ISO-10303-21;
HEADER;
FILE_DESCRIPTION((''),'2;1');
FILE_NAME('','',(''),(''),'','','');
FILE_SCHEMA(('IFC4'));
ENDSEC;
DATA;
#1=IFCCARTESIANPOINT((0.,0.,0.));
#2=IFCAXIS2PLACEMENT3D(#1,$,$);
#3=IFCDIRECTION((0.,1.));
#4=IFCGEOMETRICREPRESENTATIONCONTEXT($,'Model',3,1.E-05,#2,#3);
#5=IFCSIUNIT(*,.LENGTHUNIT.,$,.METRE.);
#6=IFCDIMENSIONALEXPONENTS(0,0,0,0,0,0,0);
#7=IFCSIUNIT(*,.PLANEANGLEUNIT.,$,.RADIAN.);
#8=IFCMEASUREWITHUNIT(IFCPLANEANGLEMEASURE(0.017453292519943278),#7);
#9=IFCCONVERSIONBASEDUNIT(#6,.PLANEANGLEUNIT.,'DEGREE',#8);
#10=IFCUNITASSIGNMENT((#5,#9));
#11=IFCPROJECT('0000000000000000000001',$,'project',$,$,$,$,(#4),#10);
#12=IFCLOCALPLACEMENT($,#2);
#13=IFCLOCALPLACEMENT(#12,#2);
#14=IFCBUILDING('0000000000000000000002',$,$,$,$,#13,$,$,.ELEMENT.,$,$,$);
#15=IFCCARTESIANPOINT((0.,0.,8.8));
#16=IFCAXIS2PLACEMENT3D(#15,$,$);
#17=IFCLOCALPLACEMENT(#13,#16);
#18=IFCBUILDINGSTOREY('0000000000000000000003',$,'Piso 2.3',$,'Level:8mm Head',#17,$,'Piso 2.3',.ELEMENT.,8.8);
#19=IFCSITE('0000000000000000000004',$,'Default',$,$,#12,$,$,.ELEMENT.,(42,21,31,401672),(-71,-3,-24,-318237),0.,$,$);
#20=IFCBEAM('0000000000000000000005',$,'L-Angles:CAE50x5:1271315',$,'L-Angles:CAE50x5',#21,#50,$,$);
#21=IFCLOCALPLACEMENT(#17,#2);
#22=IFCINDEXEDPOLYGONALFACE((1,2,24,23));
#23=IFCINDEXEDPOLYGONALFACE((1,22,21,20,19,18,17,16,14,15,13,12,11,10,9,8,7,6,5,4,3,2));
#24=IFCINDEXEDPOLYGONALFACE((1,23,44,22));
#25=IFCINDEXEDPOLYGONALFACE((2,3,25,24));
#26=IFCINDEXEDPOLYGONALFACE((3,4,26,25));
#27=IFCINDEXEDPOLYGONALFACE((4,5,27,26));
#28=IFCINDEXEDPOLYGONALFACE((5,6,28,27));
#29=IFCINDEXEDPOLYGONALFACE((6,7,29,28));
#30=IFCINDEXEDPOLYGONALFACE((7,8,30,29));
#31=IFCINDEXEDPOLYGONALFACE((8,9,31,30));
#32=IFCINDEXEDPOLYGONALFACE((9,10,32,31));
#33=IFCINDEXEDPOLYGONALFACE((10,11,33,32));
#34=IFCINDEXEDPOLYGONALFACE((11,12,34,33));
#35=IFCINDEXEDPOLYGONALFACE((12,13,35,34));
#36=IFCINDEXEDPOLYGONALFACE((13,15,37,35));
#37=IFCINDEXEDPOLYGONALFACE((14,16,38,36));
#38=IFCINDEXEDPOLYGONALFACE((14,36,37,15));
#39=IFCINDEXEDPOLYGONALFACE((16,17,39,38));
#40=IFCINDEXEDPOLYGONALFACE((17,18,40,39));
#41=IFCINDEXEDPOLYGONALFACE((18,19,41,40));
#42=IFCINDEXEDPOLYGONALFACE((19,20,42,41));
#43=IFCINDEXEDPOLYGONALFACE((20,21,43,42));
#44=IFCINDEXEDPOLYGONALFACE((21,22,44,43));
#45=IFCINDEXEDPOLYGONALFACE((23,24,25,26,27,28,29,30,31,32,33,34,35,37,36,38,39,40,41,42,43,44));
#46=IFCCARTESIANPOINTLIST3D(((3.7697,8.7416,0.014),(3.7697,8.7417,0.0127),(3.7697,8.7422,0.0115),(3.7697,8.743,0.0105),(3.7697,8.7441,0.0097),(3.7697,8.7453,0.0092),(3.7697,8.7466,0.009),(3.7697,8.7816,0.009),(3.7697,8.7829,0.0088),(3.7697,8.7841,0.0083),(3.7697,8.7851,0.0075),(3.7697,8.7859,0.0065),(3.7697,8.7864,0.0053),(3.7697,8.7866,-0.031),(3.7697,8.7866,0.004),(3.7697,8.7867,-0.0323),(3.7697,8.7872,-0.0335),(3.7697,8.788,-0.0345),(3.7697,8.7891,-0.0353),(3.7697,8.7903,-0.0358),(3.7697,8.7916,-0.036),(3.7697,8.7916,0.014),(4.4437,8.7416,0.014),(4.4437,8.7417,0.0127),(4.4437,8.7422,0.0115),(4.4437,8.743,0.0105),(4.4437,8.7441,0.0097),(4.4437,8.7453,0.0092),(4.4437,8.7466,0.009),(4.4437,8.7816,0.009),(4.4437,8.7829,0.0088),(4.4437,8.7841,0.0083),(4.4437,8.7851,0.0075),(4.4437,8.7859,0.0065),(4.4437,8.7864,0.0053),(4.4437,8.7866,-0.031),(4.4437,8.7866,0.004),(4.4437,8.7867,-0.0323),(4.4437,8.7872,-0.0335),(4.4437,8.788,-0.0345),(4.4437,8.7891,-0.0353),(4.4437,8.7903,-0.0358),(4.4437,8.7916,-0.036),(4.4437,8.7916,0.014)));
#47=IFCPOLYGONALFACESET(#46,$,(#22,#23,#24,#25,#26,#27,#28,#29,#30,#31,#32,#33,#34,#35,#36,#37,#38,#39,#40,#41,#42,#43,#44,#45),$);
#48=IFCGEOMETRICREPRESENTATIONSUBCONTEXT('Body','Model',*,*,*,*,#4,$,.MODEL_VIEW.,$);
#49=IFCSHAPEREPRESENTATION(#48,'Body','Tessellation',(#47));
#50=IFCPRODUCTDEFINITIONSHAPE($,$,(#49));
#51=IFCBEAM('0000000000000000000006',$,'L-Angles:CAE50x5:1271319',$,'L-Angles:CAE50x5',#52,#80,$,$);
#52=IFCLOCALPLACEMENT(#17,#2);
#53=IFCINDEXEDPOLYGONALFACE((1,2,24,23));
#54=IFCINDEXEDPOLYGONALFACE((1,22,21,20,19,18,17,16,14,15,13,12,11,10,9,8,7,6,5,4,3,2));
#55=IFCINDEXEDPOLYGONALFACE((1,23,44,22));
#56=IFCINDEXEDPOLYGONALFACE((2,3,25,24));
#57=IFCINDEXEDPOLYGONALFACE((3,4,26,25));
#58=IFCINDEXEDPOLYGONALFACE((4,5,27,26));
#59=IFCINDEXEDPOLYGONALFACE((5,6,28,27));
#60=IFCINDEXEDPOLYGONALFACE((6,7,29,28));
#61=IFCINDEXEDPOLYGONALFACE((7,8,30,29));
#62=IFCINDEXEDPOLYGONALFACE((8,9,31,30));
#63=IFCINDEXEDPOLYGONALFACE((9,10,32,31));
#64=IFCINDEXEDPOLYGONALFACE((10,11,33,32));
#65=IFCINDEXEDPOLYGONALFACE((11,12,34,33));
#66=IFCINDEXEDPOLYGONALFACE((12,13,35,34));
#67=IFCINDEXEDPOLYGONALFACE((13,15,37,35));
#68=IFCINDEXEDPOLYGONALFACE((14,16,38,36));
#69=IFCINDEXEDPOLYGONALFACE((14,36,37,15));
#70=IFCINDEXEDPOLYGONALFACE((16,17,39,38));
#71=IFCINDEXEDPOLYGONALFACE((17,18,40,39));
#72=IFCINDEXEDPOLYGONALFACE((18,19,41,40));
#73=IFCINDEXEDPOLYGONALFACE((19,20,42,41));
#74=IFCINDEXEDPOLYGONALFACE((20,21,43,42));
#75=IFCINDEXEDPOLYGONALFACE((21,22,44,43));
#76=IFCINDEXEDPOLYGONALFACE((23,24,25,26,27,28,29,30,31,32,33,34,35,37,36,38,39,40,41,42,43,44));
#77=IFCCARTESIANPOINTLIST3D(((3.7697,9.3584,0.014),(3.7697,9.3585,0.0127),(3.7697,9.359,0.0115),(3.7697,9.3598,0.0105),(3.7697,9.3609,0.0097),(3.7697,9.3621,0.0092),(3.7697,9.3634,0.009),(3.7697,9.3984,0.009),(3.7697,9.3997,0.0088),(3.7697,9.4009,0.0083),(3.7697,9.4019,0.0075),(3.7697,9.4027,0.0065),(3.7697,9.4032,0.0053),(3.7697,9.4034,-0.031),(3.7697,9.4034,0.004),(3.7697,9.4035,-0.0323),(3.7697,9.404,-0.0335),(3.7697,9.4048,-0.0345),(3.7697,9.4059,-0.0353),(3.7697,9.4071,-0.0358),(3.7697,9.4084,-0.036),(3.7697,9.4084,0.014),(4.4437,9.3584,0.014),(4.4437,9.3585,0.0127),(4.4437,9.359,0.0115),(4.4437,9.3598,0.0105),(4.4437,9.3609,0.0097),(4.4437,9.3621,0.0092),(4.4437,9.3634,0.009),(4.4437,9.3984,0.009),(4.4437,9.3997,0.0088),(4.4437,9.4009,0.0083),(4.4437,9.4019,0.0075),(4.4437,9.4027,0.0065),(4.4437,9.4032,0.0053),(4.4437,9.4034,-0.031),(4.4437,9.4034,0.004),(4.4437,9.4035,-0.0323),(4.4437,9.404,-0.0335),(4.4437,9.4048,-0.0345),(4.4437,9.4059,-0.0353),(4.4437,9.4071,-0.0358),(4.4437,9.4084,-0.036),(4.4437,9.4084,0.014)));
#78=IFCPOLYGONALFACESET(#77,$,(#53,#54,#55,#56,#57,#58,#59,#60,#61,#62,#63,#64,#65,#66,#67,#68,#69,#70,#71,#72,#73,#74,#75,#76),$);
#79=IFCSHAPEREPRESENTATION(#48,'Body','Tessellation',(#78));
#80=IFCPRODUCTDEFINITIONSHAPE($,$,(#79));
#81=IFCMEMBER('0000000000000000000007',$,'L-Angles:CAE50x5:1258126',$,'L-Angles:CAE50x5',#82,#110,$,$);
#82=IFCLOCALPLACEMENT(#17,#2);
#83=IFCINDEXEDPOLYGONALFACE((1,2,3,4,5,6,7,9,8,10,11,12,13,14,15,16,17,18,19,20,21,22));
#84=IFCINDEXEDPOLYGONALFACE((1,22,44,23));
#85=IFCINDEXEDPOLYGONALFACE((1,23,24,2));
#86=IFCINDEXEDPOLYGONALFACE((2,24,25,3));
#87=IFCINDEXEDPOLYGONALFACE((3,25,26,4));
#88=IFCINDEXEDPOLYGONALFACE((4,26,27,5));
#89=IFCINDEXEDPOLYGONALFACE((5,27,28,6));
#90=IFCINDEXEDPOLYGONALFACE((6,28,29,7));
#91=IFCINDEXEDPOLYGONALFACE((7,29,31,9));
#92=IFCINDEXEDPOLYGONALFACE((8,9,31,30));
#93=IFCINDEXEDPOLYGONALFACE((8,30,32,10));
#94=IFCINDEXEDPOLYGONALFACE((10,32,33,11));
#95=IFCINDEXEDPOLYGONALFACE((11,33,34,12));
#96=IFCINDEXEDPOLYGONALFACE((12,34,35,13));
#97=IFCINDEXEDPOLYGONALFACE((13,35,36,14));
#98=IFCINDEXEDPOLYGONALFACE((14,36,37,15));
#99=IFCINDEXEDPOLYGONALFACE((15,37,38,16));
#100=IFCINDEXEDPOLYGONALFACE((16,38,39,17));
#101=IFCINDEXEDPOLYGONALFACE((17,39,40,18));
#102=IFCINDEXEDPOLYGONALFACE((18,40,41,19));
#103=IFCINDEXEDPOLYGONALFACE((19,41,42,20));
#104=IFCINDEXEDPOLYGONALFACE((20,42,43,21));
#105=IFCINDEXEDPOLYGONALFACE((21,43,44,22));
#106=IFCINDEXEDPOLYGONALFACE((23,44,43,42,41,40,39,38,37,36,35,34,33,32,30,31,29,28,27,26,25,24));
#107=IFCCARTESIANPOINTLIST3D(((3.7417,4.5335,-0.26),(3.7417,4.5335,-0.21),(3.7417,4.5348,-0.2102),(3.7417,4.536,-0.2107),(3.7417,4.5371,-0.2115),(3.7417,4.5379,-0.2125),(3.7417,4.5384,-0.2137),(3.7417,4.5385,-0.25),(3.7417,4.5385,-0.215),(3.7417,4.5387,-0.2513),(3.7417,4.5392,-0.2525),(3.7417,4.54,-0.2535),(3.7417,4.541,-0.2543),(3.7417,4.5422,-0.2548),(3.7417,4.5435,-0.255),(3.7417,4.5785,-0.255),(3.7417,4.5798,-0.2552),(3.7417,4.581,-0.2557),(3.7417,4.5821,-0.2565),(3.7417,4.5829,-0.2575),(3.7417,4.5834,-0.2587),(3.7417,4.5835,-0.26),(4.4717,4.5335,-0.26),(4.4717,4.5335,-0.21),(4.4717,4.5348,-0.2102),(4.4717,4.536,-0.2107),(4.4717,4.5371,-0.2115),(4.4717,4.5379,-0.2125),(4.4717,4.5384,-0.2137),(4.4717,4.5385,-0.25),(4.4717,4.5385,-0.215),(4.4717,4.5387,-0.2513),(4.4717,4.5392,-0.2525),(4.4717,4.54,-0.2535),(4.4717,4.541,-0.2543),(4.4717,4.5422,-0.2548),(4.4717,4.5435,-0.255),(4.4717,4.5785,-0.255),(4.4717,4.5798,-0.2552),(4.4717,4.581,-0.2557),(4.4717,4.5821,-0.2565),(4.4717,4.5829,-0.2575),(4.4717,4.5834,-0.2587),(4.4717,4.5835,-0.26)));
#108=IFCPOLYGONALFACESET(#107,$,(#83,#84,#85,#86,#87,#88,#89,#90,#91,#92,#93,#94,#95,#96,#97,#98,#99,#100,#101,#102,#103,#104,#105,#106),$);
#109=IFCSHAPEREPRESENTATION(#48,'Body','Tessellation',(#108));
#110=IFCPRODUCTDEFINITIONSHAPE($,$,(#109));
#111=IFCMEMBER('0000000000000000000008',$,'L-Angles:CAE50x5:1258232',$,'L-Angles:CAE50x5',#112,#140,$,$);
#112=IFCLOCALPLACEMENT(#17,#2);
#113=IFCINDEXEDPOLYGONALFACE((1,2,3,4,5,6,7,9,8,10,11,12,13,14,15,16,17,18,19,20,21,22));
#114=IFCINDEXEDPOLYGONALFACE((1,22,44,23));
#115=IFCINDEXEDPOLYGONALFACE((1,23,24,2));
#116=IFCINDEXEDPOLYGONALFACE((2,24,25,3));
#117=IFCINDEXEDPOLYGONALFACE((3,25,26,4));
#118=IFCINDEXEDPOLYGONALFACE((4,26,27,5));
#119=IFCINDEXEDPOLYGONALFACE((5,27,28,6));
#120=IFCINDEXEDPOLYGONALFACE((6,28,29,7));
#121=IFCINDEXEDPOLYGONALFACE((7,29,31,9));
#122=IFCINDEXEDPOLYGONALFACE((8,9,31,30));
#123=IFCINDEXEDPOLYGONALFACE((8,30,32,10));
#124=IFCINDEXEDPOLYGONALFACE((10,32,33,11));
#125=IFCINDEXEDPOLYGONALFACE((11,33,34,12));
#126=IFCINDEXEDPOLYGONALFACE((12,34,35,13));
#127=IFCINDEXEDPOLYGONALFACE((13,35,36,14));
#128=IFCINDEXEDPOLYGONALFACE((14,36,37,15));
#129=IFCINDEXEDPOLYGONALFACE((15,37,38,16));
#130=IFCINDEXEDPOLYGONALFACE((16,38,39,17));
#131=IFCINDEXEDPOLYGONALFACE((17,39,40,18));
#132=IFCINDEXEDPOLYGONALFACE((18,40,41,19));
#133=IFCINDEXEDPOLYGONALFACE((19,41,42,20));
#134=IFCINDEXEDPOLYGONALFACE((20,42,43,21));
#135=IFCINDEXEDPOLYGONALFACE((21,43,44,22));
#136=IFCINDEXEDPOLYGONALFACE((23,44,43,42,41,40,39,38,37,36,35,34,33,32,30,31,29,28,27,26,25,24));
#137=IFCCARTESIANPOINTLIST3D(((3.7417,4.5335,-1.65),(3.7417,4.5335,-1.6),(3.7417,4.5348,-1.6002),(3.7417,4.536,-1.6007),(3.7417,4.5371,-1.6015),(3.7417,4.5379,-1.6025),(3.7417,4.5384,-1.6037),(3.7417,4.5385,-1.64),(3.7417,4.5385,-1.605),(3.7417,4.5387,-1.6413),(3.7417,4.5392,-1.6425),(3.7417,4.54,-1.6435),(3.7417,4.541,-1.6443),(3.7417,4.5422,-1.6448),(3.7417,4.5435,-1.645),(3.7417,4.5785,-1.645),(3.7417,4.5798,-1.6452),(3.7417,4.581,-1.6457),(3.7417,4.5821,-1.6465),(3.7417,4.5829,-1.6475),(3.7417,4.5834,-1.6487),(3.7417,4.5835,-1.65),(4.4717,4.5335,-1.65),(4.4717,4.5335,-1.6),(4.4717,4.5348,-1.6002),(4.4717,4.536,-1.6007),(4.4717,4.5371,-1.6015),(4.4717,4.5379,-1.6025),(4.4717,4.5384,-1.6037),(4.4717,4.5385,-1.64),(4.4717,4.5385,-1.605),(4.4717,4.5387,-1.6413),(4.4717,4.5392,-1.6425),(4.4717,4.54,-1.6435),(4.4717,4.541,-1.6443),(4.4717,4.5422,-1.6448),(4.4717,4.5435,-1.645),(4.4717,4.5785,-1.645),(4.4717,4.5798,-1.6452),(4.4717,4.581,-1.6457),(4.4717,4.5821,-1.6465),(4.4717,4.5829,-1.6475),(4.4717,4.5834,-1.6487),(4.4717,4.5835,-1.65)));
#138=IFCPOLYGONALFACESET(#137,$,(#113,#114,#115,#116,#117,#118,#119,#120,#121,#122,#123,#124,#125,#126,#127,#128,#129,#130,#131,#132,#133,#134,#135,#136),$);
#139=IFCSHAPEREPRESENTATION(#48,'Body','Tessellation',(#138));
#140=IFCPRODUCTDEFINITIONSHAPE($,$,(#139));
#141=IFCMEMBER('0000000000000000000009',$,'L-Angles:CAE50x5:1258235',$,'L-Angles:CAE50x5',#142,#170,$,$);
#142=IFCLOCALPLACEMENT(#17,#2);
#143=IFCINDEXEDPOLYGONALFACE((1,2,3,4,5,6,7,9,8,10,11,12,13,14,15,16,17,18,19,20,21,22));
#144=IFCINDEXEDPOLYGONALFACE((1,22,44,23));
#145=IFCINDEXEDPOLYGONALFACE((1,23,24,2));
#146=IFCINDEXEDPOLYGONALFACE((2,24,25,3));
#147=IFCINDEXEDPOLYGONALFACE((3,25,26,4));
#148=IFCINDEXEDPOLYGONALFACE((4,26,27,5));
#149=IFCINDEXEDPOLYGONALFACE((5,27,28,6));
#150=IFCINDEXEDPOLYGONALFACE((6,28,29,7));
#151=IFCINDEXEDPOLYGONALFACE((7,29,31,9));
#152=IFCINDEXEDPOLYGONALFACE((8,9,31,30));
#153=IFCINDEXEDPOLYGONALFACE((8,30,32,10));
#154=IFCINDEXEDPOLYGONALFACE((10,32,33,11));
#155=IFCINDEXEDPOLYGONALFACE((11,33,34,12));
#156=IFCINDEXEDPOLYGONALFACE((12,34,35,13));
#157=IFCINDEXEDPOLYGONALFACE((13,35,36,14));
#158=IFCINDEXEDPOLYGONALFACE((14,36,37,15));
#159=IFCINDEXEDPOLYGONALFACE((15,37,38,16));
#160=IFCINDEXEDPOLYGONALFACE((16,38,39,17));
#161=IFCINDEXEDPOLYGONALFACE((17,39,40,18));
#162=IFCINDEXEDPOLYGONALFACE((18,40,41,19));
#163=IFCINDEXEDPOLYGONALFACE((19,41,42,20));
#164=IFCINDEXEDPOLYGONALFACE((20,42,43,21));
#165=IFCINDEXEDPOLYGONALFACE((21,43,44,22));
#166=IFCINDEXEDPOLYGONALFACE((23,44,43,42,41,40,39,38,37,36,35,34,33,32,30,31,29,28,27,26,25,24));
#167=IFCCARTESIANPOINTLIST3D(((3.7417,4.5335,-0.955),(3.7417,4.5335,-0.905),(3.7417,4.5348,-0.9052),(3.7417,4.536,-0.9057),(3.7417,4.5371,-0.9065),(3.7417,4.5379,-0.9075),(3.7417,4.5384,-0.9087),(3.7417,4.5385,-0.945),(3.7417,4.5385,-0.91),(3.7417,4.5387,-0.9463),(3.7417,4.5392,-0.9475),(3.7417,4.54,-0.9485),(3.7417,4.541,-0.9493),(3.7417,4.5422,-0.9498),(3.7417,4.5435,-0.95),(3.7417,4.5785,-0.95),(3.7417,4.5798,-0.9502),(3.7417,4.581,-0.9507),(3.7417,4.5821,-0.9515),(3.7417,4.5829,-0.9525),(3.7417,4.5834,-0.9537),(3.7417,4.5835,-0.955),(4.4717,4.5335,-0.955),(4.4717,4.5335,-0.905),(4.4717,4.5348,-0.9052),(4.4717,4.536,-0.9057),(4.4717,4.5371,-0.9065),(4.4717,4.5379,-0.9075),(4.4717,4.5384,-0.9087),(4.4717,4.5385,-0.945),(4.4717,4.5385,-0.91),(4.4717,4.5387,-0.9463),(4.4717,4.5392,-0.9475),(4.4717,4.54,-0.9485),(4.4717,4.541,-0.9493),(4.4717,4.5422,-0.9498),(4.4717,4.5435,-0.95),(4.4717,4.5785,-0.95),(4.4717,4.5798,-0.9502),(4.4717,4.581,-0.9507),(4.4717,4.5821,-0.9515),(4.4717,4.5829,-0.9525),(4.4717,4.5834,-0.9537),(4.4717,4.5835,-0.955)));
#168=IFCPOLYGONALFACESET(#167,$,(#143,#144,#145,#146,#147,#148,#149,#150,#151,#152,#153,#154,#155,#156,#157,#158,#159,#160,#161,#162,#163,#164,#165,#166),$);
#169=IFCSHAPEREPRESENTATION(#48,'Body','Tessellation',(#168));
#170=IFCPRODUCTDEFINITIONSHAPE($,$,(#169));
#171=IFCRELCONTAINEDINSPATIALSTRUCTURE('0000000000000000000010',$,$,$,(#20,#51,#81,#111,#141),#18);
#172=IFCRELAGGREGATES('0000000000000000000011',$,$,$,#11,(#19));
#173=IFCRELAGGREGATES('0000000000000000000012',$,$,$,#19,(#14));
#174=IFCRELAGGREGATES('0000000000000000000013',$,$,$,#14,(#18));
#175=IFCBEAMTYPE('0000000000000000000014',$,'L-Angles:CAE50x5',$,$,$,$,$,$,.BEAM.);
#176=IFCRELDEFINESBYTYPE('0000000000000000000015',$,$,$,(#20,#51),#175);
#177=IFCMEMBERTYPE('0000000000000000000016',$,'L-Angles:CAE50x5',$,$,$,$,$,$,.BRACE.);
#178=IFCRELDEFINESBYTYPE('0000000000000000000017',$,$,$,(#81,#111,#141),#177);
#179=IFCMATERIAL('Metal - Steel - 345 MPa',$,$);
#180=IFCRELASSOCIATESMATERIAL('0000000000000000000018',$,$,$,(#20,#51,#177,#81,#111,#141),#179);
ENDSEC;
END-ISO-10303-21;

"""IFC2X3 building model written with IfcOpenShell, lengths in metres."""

from ifc_helpers import new_model, entity, si_unit, converted_unit, direction, frame, frame_2d, origin, place, context, subcontext, project, spatial, polyline, circle_curve, parameter, trimmed, segment, composite_curve, outline, extrude, source, transform, mapped, material, type_object, type_shapes, element, save


model = new_model("IFC2X3")

# Units and contexts
model_context = context("Model", 3, precision=1e-05, world=origin(), true_north=direction((0.0, 1.0)))
body_context = subcontext(model_context, "Body", "Model", "MODEL_VIEW")
ifc_project = project(units=[si_unit("LENGTHUNIT", "METRE"), converted_unit("PLANEANGLEUNIT", "DEGREE", entity("IfcPlaneAngleMeasure", 0.017453292519943278), si_unit("PLANEANGLEUNIT", "RADIAN"), dimensions=[0, 0, 0, 0, 0, 0, 0])], contexts=[model_context])

# Site, building, storey
site_placement = place(None, origin())
site = spatial("IfcSite", under=ifc_project, at=site_placement, Name="Default", CompositionType="ELEMENT", RefLatitude=(42, 21, 31, 401672), RefLongitude=(-71, -3, -24, -318237), RefElevation=0.0)
building_placement = place(site_placement, origin())
building = spatial("IfcBuilding", under=site, at=building_placement, CompositionType="ELEMENT")
storey_placement = place(building_placement, frame((0.0, 0.0, 8.8)))
storey = spatial("IfcBuildingStorey", under=building, at=storey_placement, Name="Piso 2.3", ObjectType="Level:8mm Head", LongName="Piso 2.3", CompositionType="ELEMENT", Elevation=8.8)

# Shared definitions
ifc_material = material(Name="Metal - Steel - 345 MPa")

# Beams
beam_type_1 = type_object("IfcBeamType", Name="L-Angles:CAE50x5", PredefinedType="BEAM")
beam_1_placement = place(storey_placement, frame((3.7067, 8.7776, 0.0)))
element("IfcBeam", 1, at=beam_1_placement, inside=storey, type_object=beam_type_1, material=ifc_material, Name="L-Angles:CAE50x5:1271315", ObjectType="L-Angles:CAE50x5", context=body_context, shape_type="SweptSolid", body=[
    extrude(outline(composite_curve([segment(polyline([(-0.0336, -0.0164), (0.0164, -0.0164)]), True, "CONTINUOUS"), segment(polyline([(0.0164, -0.0164), (0.0164, 0.0336)]), True, "CONTINUOUS"), segment(trimmed(circle_curve(frame_2d((0.0164, 0.0286), x_axis=(0.0, 1.0)), 0.005), [parameter(0.0)], [parameter(90.0)], True, "PARAMETER"), True, "CONTINUOUS"), segment(polyline([(0.0114, 0.0286), (0.0114, -0.0064)]), True, "CONTINUOUS"), segment(trimmed(circle_curve(frame_2d((0.0064, -0.0064), x_axis=(1.0, 0.0)), 0.005), [parameter(270.0)], [parameter(0.0)], True, "PARAMETER"), False, "CONTINUOUS"), segment(polyline([(0.0064, -0.0114), (-0.0286, -0.0114)]), True, "CONTINUOUS"), segment(trimmed(circle_curve(frame_2d((-0.0286, -0.0164), x_axis=(0.0, 1.0)), 0.005), [parameter(0.0)], [parameter(90.0)], True, "PARAMETER"), True, "CONTINUOUS")], self_intersect=False)), frame((0.063, -0.0024, -0.0024), z_axis=(1.0, 0.0, 0.0), x_axis=(0.0, 0.0, 1.0)), (0.0, 0.0, 1.0), 0.674),
])
beam_2_placement = place(storey_placement, frame((3.7067, 9.3944, 0.0)))
element("IfcBeam", 2, at=beam_2_placement, inside=storey, type_object=beam_type_1, material=ifc_material, Name="L-Angles:CAE50x5:1271319", ObjectType="L-Angles:CAE50x5", context=body_context, shape_type="SweptSolid", body=[
    extrude(outline(composite_curve([segment(polyline([(-0.0336, -0.0164), (0.0164, -0.0164)]), True, "CONTINUOUS"), segment(polyline([(0.0164, -0.0164), (0.0164, 0.0336)]), True, "CONTINUOUS"), segment(trimmed(circle_curve(frame_2d((0.0164, 0.0286), x_axis=(0.0, 1.0)), 0.005), [parameter(0.0)], [parameter(90.0)], True, "PARAMETER"), True, "CONTINUOUS"), segment(polyline([(0.0114, 0.0286), (0.0114, -0.0064)]), True, "CONTINUOUS"), segment(trimmed(circle_curve(frame_2d((0.0064, -0.0064), x_axis=(1.0, 0.0)), 0.005), [parameter(270.0)], [parameter(0.0)], True, "PARAMETER"), False, "CONTINUOUS"), segment(polyline([(0.0064, -0.0114), (-0.0286, -0.0114)]), True, "CONTINUOUS"), segment(trimmed(circle_curve(frame_2d((-0.0286, -0.0164), x_axis=(0.0, 1.0)), 0.005), [parameter(0.0)], [parameter(90.0)], True, "PARAMETER"), True, "CONTINUOUS")], self_intersect=False)), frame((0.063, -0.0024, -0.0024), z_axis=(1.0, 0.0, 0.0), x_axis=(0.0, 0.0, 1.0)), (0.0, 0.0, 1.0), 0.674),
])

# Members
member_type_1 = type_object("IfcMemberType", Name="L-Angles:CAE50x5", PredefinedType="BRACE", material=ifc_material)
shared_shape_1 = source(origin(), body_context, "Body", "SweptSolid", [
    extrude(outline(composite_curve([segment(polyline([(-0.0164, -0.0164), (0.0336, -0.0164)]), True, "CONTINUOUS"), segment(trimmed(circle_curve(frame_2d((0.0286, -0.0164), x_axis=(1.0, 0.0)), 0.005), [parameter(0.0)], [parameter(90.0)], True, "PARAMETER"), True, "CONTINUOUS"), segment(polyline([(0.0286, -0.0114), (-0.0064, -0.0114)]), True, "CONTINUOUS"), segment(trimmed(circle_curve(frame_2d((-0.0064, -0.0064), x_axis=(1.0, 0.0)), 0.005), [parameter(180.0)], [parameter(270.0)], True, "PARAMETER"), False, "CONTINUOUS"), segment(polyline([(-0.0114, -0.0064), (-0.0114, 0.0286)]), True, "CONTINUOUS"), segment(trimmed(circle_curve(frame_2d((-0.0164, 0.0286), x_axis=(1.0, 0.0)), 0.005), [parameter(0.0)], [parameter(90.0)], True, "PARAMETER"), True, "CONTINUOUS"), segment(polyline([(-0.0164, 0.0336), (-0.0164, -0.0164)]), True, "CONTINUOUS")], self_intersect=False)), frame((-0.365, -0.0024, -0.0024), z_axis=(1.0, 0.0, 0.0), x_axis=(0.0, -1.0, 0.0)), (0.0, 0.0, 1.0), 0.73),
])
type_shapes(member_type_1, [shared_shape_1])
for number, where, z_axis, x_axis, name in (
    (3, (4.1067, 4.5475, -0.246), (0.0, -1.0, 0.0), (-1.0, 0.0, 0.0), "L-Angles:CAE50x5:1258126"),
    (4, (4.1067, 4.5475, -1.636), (0.0, -1.0, 0.0), (-1.0, 0.0, 0.0), "L-Angles:CAE50x5:1258232"),
    (5, (4.1067, 4.5475, -0.941), (0.0, -1.0, 0.0), (-1.0, 0.0, 0.0), "L-Angles:CAE50x5:1258235"),
):
    element("IfcMember", number, at=place(storey_placement, frame(where, z_axis=z_axis, x_axis=x_axis)), inside=storey, type_object=member_type_1, material=ifc_material, Name=name, ObjectType="L-Angles:CAE50x5", context=body_context, shape_type="MappedRepresentation", body=[
        mapped(shared_shape_1, transform((0.0, 0.0, 0.0), scale=1.0)),
    ])

save(model, "model.ifc")
